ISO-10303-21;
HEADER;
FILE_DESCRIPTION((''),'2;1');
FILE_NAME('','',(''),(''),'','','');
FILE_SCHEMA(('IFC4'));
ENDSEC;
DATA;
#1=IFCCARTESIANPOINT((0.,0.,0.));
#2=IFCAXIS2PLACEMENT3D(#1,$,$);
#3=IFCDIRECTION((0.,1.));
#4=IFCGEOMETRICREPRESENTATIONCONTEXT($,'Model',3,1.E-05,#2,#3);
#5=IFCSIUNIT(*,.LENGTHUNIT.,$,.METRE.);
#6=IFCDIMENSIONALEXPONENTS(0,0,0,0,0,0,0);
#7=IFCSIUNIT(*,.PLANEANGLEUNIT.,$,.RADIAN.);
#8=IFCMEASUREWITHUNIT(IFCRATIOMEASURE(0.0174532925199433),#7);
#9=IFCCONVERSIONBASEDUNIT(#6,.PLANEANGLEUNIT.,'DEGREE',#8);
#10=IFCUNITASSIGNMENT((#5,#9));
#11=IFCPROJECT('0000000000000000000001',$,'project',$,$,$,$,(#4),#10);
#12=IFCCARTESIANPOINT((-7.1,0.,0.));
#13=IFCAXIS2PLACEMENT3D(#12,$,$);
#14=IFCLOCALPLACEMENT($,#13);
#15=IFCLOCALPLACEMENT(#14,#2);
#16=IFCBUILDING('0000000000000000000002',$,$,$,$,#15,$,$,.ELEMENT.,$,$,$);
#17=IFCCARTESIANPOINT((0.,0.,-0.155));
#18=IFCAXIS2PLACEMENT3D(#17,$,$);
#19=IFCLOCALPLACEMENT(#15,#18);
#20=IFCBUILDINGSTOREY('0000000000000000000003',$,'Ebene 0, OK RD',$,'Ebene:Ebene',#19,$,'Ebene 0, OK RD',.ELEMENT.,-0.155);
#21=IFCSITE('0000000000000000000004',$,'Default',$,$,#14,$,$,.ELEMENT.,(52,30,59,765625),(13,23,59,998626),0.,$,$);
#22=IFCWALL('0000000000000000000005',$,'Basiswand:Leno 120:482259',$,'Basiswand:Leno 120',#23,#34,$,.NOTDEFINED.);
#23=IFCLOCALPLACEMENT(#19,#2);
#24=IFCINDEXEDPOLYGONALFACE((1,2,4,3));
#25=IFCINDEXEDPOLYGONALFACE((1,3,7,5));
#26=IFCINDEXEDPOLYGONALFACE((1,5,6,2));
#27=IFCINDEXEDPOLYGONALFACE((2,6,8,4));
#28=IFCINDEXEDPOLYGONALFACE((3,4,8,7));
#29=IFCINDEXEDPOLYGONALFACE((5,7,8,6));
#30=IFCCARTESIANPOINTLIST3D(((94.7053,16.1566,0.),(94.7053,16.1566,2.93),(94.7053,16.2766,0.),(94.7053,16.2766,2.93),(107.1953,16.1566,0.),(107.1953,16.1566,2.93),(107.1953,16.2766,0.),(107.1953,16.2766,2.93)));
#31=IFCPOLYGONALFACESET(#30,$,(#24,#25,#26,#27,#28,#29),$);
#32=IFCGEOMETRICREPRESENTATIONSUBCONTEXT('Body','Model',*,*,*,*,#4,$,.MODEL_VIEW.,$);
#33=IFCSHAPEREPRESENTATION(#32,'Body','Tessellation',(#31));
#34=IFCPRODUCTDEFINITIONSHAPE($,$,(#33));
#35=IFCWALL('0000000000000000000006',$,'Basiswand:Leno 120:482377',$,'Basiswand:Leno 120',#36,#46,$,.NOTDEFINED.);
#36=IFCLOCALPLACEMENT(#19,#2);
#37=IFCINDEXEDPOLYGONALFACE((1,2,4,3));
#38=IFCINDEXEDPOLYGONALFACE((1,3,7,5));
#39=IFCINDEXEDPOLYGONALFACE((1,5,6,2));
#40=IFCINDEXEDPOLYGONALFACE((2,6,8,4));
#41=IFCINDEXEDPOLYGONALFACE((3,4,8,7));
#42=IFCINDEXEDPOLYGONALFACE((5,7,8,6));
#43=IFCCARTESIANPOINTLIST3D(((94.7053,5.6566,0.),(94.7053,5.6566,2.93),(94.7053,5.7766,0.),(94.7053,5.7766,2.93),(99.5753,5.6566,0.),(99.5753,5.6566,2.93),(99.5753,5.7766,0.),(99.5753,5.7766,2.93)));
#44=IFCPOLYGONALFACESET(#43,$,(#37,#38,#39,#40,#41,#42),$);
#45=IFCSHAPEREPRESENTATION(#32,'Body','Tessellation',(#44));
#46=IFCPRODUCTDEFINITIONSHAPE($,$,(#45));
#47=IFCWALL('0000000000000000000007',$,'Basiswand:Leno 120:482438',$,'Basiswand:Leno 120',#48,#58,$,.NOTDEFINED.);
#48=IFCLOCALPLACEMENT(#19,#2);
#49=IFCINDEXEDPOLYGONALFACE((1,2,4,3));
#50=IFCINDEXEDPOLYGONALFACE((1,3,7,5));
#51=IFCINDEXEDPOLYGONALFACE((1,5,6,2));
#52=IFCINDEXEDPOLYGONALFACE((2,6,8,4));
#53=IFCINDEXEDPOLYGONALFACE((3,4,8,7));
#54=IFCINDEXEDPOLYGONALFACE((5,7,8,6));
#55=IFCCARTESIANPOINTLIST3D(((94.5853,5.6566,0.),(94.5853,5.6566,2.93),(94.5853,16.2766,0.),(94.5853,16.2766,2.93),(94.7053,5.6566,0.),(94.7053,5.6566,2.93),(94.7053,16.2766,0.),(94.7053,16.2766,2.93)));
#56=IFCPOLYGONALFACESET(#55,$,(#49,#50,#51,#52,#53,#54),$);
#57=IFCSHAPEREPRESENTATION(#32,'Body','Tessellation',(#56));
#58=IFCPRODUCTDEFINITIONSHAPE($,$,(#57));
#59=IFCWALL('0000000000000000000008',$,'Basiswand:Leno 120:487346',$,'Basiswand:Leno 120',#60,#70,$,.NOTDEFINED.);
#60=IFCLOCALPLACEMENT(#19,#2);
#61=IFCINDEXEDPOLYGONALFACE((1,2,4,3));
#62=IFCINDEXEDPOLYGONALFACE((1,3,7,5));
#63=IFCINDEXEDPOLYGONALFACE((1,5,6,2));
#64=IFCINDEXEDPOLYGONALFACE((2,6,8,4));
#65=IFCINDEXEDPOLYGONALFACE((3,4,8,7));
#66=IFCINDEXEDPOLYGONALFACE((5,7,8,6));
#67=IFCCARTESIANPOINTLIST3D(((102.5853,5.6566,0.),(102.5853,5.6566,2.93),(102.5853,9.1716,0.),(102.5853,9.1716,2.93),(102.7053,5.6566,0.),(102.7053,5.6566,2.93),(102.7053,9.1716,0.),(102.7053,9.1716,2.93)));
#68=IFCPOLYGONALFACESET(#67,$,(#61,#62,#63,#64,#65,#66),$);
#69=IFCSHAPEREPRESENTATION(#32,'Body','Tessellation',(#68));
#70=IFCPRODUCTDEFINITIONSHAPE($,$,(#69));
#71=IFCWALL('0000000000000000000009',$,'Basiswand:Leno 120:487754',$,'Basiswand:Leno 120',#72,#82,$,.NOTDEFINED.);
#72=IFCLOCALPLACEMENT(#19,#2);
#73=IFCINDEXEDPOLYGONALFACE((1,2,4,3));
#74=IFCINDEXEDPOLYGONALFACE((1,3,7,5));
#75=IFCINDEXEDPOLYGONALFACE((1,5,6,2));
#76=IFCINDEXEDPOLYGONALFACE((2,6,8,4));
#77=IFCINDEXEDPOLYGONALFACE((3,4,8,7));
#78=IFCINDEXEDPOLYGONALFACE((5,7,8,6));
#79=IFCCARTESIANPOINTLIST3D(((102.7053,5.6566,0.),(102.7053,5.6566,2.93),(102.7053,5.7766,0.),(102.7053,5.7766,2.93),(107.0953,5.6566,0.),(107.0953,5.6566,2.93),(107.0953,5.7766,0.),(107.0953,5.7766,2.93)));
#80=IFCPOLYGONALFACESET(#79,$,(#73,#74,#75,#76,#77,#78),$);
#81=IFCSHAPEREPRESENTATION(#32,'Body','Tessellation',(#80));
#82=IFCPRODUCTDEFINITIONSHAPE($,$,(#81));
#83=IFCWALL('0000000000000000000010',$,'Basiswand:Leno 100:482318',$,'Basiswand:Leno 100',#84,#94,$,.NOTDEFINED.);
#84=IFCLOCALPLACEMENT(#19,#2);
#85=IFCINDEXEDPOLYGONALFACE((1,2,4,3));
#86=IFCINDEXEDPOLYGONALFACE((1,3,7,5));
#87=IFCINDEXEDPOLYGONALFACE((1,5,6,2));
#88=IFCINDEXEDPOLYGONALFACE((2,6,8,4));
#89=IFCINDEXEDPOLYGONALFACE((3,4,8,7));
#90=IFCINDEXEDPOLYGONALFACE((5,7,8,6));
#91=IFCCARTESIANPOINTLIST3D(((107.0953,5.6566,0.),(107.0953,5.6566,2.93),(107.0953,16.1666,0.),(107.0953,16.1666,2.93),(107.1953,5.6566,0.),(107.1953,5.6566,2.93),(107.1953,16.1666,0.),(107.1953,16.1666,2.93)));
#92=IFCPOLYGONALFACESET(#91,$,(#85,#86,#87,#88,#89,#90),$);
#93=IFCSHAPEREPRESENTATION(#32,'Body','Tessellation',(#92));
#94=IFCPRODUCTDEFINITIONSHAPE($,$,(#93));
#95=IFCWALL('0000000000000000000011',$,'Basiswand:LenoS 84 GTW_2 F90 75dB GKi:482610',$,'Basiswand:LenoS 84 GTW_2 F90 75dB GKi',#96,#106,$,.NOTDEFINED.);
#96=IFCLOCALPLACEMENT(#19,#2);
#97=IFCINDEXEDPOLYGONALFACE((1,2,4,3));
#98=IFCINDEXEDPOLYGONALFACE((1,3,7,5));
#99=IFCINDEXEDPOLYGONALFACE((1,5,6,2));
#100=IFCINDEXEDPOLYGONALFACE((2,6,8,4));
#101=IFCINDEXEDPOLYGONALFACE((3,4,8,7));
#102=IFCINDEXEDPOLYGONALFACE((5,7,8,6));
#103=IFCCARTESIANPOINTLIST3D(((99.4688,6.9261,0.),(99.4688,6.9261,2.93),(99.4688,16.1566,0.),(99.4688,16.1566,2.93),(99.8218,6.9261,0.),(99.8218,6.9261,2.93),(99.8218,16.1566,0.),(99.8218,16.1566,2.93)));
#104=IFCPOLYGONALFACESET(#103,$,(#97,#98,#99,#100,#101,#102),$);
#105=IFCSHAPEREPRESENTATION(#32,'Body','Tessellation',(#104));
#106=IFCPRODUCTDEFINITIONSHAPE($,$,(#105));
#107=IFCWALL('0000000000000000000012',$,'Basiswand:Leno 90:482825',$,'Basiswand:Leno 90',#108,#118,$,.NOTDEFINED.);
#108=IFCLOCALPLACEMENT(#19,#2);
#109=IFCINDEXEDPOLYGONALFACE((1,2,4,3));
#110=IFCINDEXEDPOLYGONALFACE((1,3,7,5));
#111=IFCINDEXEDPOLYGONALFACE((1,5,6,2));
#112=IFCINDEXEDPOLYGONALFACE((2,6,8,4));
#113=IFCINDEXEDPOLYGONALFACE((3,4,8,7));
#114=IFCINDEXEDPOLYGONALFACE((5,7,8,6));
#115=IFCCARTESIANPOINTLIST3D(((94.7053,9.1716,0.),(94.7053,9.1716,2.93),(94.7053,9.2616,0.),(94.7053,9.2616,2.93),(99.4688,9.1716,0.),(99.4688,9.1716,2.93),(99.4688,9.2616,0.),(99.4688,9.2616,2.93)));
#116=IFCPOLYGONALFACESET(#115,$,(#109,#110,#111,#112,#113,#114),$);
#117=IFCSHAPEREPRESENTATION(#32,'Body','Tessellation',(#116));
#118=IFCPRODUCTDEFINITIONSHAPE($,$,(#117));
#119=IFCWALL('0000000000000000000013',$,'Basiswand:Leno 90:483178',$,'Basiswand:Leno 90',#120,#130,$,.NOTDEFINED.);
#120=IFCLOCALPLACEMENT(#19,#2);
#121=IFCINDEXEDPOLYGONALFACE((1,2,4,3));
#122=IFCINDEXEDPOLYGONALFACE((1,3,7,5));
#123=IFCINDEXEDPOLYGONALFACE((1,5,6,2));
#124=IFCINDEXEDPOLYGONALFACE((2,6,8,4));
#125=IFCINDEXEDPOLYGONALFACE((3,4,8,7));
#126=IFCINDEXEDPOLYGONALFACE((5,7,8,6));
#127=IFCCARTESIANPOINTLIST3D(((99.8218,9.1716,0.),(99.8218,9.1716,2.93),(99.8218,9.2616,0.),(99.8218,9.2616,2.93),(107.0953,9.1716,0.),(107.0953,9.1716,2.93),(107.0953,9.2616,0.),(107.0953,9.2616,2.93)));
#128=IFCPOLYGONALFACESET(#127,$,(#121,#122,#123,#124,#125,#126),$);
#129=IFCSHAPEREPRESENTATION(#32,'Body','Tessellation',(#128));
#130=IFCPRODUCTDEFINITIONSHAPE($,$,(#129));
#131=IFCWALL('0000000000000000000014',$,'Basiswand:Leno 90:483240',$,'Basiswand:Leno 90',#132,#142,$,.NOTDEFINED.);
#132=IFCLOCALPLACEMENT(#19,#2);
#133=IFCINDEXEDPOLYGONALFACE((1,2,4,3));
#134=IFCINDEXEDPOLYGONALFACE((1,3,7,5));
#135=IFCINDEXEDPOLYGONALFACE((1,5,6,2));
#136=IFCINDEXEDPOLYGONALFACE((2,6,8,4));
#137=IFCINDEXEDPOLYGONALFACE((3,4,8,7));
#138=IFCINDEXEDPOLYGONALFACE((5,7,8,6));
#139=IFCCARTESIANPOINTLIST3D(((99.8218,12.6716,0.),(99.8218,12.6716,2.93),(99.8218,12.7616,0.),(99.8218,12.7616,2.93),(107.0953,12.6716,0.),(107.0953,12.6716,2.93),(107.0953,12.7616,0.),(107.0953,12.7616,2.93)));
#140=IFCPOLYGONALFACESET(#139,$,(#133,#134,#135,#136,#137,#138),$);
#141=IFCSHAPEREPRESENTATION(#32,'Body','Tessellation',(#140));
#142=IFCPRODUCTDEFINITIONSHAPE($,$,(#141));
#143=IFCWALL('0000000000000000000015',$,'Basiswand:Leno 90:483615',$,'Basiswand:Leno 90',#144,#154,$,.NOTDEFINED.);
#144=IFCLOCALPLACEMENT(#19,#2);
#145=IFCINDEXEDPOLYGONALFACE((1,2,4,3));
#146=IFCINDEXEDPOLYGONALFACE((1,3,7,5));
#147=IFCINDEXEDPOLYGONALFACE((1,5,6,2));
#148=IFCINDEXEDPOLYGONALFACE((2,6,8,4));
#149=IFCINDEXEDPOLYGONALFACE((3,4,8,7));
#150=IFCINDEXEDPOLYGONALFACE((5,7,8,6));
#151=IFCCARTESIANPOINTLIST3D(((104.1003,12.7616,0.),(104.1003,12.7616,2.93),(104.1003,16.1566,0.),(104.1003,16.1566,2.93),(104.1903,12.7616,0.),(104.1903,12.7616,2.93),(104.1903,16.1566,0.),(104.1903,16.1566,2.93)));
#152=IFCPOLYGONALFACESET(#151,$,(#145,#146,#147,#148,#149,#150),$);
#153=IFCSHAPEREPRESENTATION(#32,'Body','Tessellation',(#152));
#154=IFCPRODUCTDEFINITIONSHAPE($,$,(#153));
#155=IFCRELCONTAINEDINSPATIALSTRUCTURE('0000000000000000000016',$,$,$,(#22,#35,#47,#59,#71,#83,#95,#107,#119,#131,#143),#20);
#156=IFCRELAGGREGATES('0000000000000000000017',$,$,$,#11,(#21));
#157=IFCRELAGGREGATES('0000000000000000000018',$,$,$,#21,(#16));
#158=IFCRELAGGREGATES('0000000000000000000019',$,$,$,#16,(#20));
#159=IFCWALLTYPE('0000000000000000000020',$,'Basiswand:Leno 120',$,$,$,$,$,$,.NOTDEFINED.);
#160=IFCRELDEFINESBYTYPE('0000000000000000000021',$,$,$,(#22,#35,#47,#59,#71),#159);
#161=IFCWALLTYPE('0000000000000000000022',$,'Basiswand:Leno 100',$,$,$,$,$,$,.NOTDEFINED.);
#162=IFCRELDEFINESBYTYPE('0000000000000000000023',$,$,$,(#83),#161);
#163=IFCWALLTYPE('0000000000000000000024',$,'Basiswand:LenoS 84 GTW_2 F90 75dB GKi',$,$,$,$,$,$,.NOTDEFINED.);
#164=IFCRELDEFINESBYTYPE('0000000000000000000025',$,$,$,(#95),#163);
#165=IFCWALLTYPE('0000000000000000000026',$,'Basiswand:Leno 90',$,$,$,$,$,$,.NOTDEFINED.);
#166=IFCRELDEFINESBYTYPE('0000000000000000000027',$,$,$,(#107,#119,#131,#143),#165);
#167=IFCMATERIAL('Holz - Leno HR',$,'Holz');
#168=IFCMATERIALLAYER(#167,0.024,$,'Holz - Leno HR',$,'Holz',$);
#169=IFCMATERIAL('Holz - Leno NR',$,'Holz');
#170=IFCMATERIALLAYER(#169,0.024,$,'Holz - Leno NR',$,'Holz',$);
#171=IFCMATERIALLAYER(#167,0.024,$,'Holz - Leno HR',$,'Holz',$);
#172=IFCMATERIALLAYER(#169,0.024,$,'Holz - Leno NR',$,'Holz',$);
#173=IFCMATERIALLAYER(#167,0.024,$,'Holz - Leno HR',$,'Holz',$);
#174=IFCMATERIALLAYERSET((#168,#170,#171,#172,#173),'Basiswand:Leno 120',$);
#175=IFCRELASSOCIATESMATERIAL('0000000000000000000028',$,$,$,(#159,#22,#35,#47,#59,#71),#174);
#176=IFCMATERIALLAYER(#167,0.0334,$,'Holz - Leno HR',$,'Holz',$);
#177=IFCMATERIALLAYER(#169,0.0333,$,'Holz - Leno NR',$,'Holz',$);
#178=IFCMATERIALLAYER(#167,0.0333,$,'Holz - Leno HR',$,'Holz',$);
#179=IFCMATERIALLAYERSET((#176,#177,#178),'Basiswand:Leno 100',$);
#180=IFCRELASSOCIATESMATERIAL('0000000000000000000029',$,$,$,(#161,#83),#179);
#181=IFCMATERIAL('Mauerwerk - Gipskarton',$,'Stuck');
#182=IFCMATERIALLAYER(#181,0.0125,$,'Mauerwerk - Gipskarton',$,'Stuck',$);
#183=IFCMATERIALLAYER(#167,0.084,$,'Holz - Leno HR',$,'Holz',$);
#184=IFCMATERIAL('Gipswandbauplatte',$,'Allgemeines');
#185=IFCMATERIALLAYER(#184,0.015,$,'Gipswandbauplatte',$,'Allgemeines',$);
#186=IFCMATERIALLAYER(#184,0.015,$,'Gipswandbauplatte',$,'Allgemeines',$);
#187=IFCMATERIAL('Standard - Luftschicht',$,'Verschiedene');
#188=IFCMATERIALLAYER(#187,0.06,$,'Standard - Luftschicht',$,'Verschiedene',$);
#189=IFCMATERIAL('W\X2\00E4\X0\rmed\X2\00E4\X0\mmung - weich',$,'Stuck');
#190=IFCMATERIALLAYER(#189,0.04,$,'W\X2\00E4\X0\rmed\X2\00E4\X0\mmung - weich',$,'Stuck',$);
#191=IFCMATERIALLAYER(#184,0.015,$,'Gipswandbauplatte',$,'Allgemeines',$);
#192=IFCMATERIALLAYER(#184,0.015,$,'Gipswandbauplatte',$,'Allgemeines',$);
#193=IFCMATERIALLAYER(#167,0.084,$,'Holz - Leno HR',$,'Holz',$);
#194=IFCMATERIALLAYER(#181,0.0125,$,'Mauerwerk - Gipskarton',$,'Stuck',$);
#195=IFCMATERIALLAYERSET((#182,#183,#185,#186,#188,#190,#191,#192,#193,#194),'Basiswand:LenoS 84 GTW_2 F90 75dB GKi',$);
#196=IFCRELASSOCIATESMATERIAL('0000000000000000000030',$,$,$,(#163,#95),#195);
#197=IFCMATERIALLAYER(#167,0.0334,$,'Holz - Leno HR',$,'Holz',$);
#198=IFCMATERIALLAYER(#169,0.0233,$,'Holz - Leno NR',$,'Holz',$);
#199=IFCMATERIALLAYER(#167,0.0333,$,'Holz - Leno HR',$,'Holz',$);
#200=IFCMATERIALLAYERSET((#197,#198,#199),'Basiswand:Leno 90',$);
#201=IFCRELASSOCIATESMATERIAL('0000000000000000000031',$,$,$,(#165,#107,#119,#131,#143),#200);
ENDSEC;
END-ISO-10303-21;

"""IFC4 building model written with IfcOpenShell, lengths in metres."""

from ifc_helpers import new_model, entity, si_unit, converted_unit, direction, frame, frame_2d, origin, place, context, subcontext, project, spatial, rectangle, extrude, material, layer, layer_set, layer_usage, type_object, element, save


model = new_model("IFC4")

# Units and contexts
model_context = context("Model", 3, precision=1e-05, world=origin(), true_north=direction((0.0, 1.0)))
body_context = subcontext(model_context, "Body", "Model", "MODEL_VIEW")
ifc_project = project(units=[si_unit("LENGTHUNIT", "METRE"), converted_unit("PLANEANGLEUNIT", "DEGREE", entity("IfcRatioMeasure", 0.0174532925199433), si_unit("PLANEANGLEUNIT", "RADIAN"), dimensions=[0, 0, 0, 0, 0, 0, 0])], contexts=[model_context])

# Site, building, storey
site_placement = place(None, frame((-7.1, 0.0, 0.0)))
site = spatial("IfcSite", under=ifc_project, at=site_placement, Name="Default", CompositionType="ELEMENT", RefLatitude=(52, 30, 59, 765625), RefLongitude=(13, 23, 59, 998626), RefElevation=0.0)
building_placement = place(site_placement, origin())
building = spatial("IfcBuilding", under=site, at=building_placement, CompositionType="ELEMENT")
storey_placement = place(building_placement, frame((0.0, 0.0, -0.155)))
storey = spatial("IfcBuildingStorey", under=building, at=storey_placement, Name="Ebene 0, OK RD", ObjectType="Ebene:Ebene", LongName="Ebene 0, OK RD", CompositionType="ELEMENT", Elevation=-0.155)

# Walls
ifc_material_1 = material(Name="Holz - Leno HR", Category="Holz")
ifc_layer_1 = layer(ifc_material_1, 0.024, Name="Holz - Leno HR", Category="Holz")
ifc_material_2 = material(Name="Holz - Leno NR", Category="Holz")
ifc_layer_2 = layer(ifc_material_2, 0.024, Name="Holz - Leno NR", Category="Holz")
ifc_layer_3 = layer(ifc_material_1, 0.024, Name="Holz - Leno HR", Category="Holz")
ifc_layer_4 = layer(ifc_material_2, 0.024, Name="Holz - Leno NR", Category="Holz")
ifc_layer_5 = layer(ifc_material_1, 0.024, Name="Holz - Leno HR", Category="Holz")
ifc_layer_set_1 = layer_set([ifc_layer_1, ifc_layer_2, ifc_layer_3, ifc_layer_4, ifc_layer_5], Name="Basiswand:Leno 120")
ifc_layer_usage_1 = layer_usage(ifc_layer_set_1, "AXIS2", "NEGATIVE", 0.06)
wall_type_1 = type_object("IfcWallType", Name="Basiswand:Leno 120", PredefinedType="NOTDEFINED", material=ifc_layer_set_1)
wall_1_placement = place(storey_placement, frame((94.7053, 16.2166, 0.0)))
element("IfcWall", 1, at=wall_1_placement, inside=storey, type_object=wall_type_1, material=ifc_layer_usage_1, Name="Basiswand:Leno 120:482259", ObjectType="Basiswand:Leno 120", PredefinedType="NOTDEFINED", context=body_context, shape_type="SweptSolid", body=[
    extrude(rectangle(XDim=12.49, YDim=0.12, at=frame_2d((6.245, 0.0), x_axis=(-1.0, 0.0))), origin(), (0.0, 0.0, 1.0), 2.93),
])
ifc_layer_usage_2 = layer_usage(ifc_layer_set_1, "AXIS2", "NEGATIVE", 0.06)
wall_2_placement = place(storey_placement, frame((99.5753, 5.7166, 0.0), z_axis=(0.0, 0.0, 1.0), x_axis=(-1.0, 0.0, 0.0)))
element("IfcWall", 2, at=wall_2_placement, inside=storey, type_object=wall_type_1, material=ifc_layer_usage_2, Name="Basiswand:Leno 120:482377", ObjectType="Basiswand:Leno 120", PredefinedType="NOTDEFINED", context=body_context, shape_type="SweptSolid", body=[
    extrude(rectangle(XDim=4.87, YDim=0.12, at=frame_2d((2.435, 0.0), x_axis=(-1.0, 0.0))), origin(), (0.0, 0.0, 1.0), 2.93),
])
ifc_layer_usage_3 = layer_usage(ifc_layer_set_1, "AXIS2", "NEGATIVE", 0.06)
wall_3_placement = place(storey_placement, frame((94.6453, 5.6566, 0.0), z_axis=(0.0, 0.0, 1.0), x_axis=(0.0, 1.0, 0.0)))
element("IfcWall", 3, at=wall_3_placement, inside=storey, type_object=wall_type_1, material=ifc_layer_usage_3, Name="Basiswand:Leno 120:482438", ObjectType="Basiswand:Leno 120", PredefinedType="NOTDEFINED", context=body_context, shape_type="SweptSolid", body=[
    extrude(rectangle(XDim=10.62, YDim=0.12, at=frame_2d((5.31, 0.0), x_axis=(-1.0, 0.0))), origin(), (0.0, 0.0, 1.0), 2.93),
])
ifc_layer_usage_4 = layer_usage(ifc_layer_set_1, "AXIS2", "POSITIVE", -0.06)
wall_4_placement = place(storey_placement, frame((102.6453, 9.1716, 0.0), z_axis=(0.0, 0.0, 1.0), x_axis=(0.0, -1.0, 0.0)))
element("IfcWall", 4, at=wall_4_placement, inside=storey, type_object=wall_type_1, material=ifc_layer_usage_4, Name="Basiswand:Leno 120:487346", ObjectType="Basiswand:Leno 120", PredefinedType="NOTDEFINED", context=body_context, shape_type="SweptSolid", body=[
    extrude(rectangle(XDim=3.515, YDim=0.12, at=frame_2d((1.7575, 0.0), x_axis=(-1.0, 0.0))), origin(), (0.0, 0.0, 1.0), 2.93),
])
ifc_layer_usage_5 = layer_usage(ifc_layer_set_1, "AXIS2", "NEGATIVE", 0.06)
wall_5_placement = place(storey_placement, frame((107.0953, 5.7166, 0.0), z_axis=(0.0, 0.0, 1.0), x_axis=(-1.0, 0.0, 0.0)))
element("IfcWall", 5, at=wall_5_placement, inside=storey, type_object=wall_type_1, material=ifc_layer_usage_5, Name="Basiswand:Leno 120:487754", ObjectType="Basiswand:Leno 120", PredefinedType="NOTDEFINED", context=body_context, shape_type="SweptSolid", body=[
    extrude(rectangle(XDim=4.39, YDim=0.12, at=frame_2d((2.195, 0.0), x_axis=(-1.0, 0.0))), origin(), (0.0, 0.0, 1.0), 2.93),
])
ifc_layer_6 = layer(ifc_material_1, 0.0334, Name="Holz - Leno HR", Category="Holz")
ifc_layer_7 = layer(ifc_material_2, 0.0333, Name="Holz - Leno NR", Category="Holz")
ifc_layer_8 = layer(ifc_material_1, 0.0333, Name="Holz - Leno HR", Category="Holz")
ifc_layer_set_2 = layer_set([ifc_layer_6, ifc_layer_7, ifc_layer_8], Name="Basiswand:Leno 100")
ifc_layer_usage_6 = layer_usage(ifc_layer_set_2, "AXIS2", "NEGATIVE", 0.05)
wall_type_2 = type_object("IfcWallType", Name="Basiswand:Leno 100", PredefinedType="NOTDEFINED", material=ifc_layer_set_2)
wall_6_placement = place(storey_placement, frame((107.1453, 16.1666, 0.0), z_axis=(0.0, 0.0, 1.0), x_axis=(0.0, -1.0, 0.0)))
element("IfcWall", 6, at=wall_6_placement, inside=storey, type_object=wall_type_2, material=ifc_layer_usage_6, Name="Basiswand:Leno 100:482318", ObjectType="Basiswand:Leno 100", PredefinedType="NOTDEFINED", context=body_context, shape_type="SweptSolid", body=[
    extrude(rectangle(XDim=10.51, YDim=0.1, at=frame_2d((5.255, 0.0), x_axis=(-1.0, 0.0))), origin(), (0.0, 0.0, 1.0), 2.93),
])
ifc_material_3 = material(Name="Mauerwerk - Gipskarton", Category="Stuck")
ifc_layer_9 = layer(ifc_material_3, 0.0125, Name="Mauerwerk - Gipskarton", Category="Stuck")
ifc_layer_10 = layer(ifc_material_1, 0.084, Name="Holz - Leno HR", Category="Holz")
ifc_material_4 = material(Name="Gipswandbauplatte", Category="Allgemeines")
ifc_layer_11 = layer(ifc_material_4, 0.015, Name="Gipswandbauplatte", Category="Allgemeines")
ifc_layer_12 = layer(ifc_material_4, 0.015, Name="Gipswandbauplatte", Category="Allgemeines")
ifc_material_5 = material(Name="Standard - Luftschicht", Category="Verschiedene")
ifc_layer_13 = layer(ifc_material_5, 0.06, Name="Standard - Luftschicht", Category="Verschiedene")
ifc_material_6 = material(Name="Wärmedämmung - weich", Category="Stuck")
ifc_layer_14 = layer(ifc_material_6, 0.04, Name="Wärmedämmung - weich", Category="Stuck")
ifc_layer_15 = layer(ifc_material_4, 0.015, Name="Gipswandbauplatte", Category="Allgemeines")
ifc_layer_16 = layer(ifc_material_4, 0.015, Name="Gipswandbauplatte", Category="Allgemeines")
ifc_layer_17 = layer(ifc_material_1, 0.084, Name="Holz - Leno HR", Category="Holz")
ifc_layer_18 = layer(ifc_material_3, 0.0125, Name="Mauerwerk - Gipskarton", Category="Stuck")
ifc_layer_set_3 = layer_set([ifc_layer_9, ifc_layer_10, ifc_layer_11, ifc_layer_12, ifc_layer_13, ifc_layer_14, ifc_layer_15, ifc_layer_16, ifc_layer_17, ifc_layer_18], Name="Basiswand:LenoS 84 GTW_2 F90 75dB GKi")
ifc_layer_usage_7 = layer_usage(ifc_layer_set_3, "AXIS2", "NEGATIVE", 0.1765)
wall_type_3 = type_object("IfcWallType", Name="Basiswand:LenoS 84 GTW_2 F90 75dB GKi", PredefinedType="NOTDEFINED", material=ifc_layer_set_3)
wall_7_placement = place(storey_placement, frame((99.6453, 16.1566, 0.0), z_axis=(0.0, 0.0, 1.0), x_axis=(0.0, -1.0, 0.0)))
element("IfcWall", 7, at=wall_7_placement, inside=storey, type_object=wall_type_3, material=ifc_layer_usage_7, Name="Basiswand:LenoS 84 GTW_2 F90 75dB GKi:482610", ObjectType="Basiswand:LenoS 84 GTW_2 F90 75dB GKi", PredefinedType="NOTDEFINED", context=body_context, shape_type="SweptSolid", body=[
    extrude(rectangle(XDim=9.2305, YDim=0.353, at=frame_2d((4.6152, 0.0), x_axis=(-1.0, 0.0))), origin(), (0.0, 0.0, 1.0), 2.93),
])
ifc_layer_19 = layer(ifc_material_1, 0.0334, Name="Holz - Leno HR", Category="Holz")
ifc_layer_20 = layer(ifc_material_2, 0.0233, Name="Holz - Leno NR", Category="Holz")
ifc_layer_21 = layer(ifc_material_1, 0.0333, Name="Holz - Leno HR", Category="Holz")
ifc_layer_set_4 = layer_set([ifc_layer_19, ifc_layer_20, ifc_layer_21], Name="Basiswand:Leno 90")
ifc_layer_usage_8 = layer_usage(ifc_layer_set_4, "AXIS2", "NEGATIVE", 0.045)
wall_type_4 = type_object("IfcWallType", Name="Basiswand:Leno 90", PredefinedType="NOTDEFINED", material=ifc_layer_set_4)
wall_8_placement = place(storey_placement, frame((94.7053, 9.2166, 0.0)))
element("IfcWall", 8, at=wall_8_placement, inside=storey, type_object=wall_type_4, material=ifc_layer_usage_8, Name="Basiswand:Leno 90:482825", ObjectType="Basiswand:Leno 90", PredefinedType="NOTDEFINED", context=body_context, shape_type="SweptSolid", body=[
    extrude(rectangle(XDim=4.7635, YDim=0.09, at=frame_2d((2.3817, 0.0), x_axis=(-1.0, 0.0))), origin(), (0.0, 0.0, 1.0), 2.93),
])
ifc_layer_usage_9 = layer_usage(ifc_layer_set_4, "AXIS2", "NEGATIVE", 0.045)
wall_9_placement = place(storey_placement, frame((107.0953, 9.2166, 0.0), z_axis=(0.0, 0.0, 1.0), x_axis=(-1.0, 0.0, 0.0)))
element("IfcWall", 9, at=wall_9_placement, inside=storey, type_object=wall_type_4, material=ifc_layer_usage_9, Name="Basiswand:Leno 90:483178", ObjectType="Basiswand:Leno 90", PredefinedType="NOTDEFINED", context=body_context, shape_type="SweptSolid", body=[
    extrude(rectangle(XDim=7.2735, YDim=0.09, at=frame_2d((3.6367, 0.0), x_axis=(-1.0, 0.0))), origin(), (0.0, 0.0, 1.0), 2.93),
])
ifc_layer_usage_10 = layer_usage(ifc_layer_set_4, "AXIS2", "NEGATIVE", 0.045)
wall_10_placement = place(storey_placement, frame((107.0953, 12.7166, 0.0), z_axis=(0.0, 0.0, 1.0), x_axis=(-1.0, 0.0, 0.0)))
element("IfcWall", 10, at=wall_10_placement, inside=storey, type_object=wall_type_4, material=ifc_layer_usage_10, Name="Basiswand:Leno 90:483240", ObjectType="Basiswand:Leno 90", PredefinedType="NOTDEFINED", context=body_context, shape_type="SweptSolid", body=[
    extrude(rectangle(XDim=7.2735, YDim=0.09, at=frame_2d((3.6367, 0.0), x_axis=(-1.0, 0.0))), origin(), (0.0, 0.0, 1.0), 2.93),
])
ifc_layer_usage_11 = layer_usage(ifc_layer_set_4, "AXIS2", "NEGATIVE", 0.045)
wall_11_placement = place(storey_placement, frame((104.1453, 12.7616, 0.0), z_axis=(0.0, 0.0, 1.0), x_axis=(0.0, 1.0, 0.0)))
element("IfcWall", 11, at=wall_11_placement, inside=storey, type_object=wall_type_4, material=ifc_layer_usage_11, Name="Basiswand:Leno 90:483615", ObjectType="Basiswand:Leno 90", PredefinedType="NOTDEFINED", context=body_context, shape_type="SweptSolid", body=[
    extrude(rectangle(XDim=3.395, YDim=0.09, at=frame_2d((1.6975, 0.0), x_axis=(-1.0, 0.0))), origin(), (0.0, 0.0, 1.0), 2.93),
])

save(model, "model.ifc")
